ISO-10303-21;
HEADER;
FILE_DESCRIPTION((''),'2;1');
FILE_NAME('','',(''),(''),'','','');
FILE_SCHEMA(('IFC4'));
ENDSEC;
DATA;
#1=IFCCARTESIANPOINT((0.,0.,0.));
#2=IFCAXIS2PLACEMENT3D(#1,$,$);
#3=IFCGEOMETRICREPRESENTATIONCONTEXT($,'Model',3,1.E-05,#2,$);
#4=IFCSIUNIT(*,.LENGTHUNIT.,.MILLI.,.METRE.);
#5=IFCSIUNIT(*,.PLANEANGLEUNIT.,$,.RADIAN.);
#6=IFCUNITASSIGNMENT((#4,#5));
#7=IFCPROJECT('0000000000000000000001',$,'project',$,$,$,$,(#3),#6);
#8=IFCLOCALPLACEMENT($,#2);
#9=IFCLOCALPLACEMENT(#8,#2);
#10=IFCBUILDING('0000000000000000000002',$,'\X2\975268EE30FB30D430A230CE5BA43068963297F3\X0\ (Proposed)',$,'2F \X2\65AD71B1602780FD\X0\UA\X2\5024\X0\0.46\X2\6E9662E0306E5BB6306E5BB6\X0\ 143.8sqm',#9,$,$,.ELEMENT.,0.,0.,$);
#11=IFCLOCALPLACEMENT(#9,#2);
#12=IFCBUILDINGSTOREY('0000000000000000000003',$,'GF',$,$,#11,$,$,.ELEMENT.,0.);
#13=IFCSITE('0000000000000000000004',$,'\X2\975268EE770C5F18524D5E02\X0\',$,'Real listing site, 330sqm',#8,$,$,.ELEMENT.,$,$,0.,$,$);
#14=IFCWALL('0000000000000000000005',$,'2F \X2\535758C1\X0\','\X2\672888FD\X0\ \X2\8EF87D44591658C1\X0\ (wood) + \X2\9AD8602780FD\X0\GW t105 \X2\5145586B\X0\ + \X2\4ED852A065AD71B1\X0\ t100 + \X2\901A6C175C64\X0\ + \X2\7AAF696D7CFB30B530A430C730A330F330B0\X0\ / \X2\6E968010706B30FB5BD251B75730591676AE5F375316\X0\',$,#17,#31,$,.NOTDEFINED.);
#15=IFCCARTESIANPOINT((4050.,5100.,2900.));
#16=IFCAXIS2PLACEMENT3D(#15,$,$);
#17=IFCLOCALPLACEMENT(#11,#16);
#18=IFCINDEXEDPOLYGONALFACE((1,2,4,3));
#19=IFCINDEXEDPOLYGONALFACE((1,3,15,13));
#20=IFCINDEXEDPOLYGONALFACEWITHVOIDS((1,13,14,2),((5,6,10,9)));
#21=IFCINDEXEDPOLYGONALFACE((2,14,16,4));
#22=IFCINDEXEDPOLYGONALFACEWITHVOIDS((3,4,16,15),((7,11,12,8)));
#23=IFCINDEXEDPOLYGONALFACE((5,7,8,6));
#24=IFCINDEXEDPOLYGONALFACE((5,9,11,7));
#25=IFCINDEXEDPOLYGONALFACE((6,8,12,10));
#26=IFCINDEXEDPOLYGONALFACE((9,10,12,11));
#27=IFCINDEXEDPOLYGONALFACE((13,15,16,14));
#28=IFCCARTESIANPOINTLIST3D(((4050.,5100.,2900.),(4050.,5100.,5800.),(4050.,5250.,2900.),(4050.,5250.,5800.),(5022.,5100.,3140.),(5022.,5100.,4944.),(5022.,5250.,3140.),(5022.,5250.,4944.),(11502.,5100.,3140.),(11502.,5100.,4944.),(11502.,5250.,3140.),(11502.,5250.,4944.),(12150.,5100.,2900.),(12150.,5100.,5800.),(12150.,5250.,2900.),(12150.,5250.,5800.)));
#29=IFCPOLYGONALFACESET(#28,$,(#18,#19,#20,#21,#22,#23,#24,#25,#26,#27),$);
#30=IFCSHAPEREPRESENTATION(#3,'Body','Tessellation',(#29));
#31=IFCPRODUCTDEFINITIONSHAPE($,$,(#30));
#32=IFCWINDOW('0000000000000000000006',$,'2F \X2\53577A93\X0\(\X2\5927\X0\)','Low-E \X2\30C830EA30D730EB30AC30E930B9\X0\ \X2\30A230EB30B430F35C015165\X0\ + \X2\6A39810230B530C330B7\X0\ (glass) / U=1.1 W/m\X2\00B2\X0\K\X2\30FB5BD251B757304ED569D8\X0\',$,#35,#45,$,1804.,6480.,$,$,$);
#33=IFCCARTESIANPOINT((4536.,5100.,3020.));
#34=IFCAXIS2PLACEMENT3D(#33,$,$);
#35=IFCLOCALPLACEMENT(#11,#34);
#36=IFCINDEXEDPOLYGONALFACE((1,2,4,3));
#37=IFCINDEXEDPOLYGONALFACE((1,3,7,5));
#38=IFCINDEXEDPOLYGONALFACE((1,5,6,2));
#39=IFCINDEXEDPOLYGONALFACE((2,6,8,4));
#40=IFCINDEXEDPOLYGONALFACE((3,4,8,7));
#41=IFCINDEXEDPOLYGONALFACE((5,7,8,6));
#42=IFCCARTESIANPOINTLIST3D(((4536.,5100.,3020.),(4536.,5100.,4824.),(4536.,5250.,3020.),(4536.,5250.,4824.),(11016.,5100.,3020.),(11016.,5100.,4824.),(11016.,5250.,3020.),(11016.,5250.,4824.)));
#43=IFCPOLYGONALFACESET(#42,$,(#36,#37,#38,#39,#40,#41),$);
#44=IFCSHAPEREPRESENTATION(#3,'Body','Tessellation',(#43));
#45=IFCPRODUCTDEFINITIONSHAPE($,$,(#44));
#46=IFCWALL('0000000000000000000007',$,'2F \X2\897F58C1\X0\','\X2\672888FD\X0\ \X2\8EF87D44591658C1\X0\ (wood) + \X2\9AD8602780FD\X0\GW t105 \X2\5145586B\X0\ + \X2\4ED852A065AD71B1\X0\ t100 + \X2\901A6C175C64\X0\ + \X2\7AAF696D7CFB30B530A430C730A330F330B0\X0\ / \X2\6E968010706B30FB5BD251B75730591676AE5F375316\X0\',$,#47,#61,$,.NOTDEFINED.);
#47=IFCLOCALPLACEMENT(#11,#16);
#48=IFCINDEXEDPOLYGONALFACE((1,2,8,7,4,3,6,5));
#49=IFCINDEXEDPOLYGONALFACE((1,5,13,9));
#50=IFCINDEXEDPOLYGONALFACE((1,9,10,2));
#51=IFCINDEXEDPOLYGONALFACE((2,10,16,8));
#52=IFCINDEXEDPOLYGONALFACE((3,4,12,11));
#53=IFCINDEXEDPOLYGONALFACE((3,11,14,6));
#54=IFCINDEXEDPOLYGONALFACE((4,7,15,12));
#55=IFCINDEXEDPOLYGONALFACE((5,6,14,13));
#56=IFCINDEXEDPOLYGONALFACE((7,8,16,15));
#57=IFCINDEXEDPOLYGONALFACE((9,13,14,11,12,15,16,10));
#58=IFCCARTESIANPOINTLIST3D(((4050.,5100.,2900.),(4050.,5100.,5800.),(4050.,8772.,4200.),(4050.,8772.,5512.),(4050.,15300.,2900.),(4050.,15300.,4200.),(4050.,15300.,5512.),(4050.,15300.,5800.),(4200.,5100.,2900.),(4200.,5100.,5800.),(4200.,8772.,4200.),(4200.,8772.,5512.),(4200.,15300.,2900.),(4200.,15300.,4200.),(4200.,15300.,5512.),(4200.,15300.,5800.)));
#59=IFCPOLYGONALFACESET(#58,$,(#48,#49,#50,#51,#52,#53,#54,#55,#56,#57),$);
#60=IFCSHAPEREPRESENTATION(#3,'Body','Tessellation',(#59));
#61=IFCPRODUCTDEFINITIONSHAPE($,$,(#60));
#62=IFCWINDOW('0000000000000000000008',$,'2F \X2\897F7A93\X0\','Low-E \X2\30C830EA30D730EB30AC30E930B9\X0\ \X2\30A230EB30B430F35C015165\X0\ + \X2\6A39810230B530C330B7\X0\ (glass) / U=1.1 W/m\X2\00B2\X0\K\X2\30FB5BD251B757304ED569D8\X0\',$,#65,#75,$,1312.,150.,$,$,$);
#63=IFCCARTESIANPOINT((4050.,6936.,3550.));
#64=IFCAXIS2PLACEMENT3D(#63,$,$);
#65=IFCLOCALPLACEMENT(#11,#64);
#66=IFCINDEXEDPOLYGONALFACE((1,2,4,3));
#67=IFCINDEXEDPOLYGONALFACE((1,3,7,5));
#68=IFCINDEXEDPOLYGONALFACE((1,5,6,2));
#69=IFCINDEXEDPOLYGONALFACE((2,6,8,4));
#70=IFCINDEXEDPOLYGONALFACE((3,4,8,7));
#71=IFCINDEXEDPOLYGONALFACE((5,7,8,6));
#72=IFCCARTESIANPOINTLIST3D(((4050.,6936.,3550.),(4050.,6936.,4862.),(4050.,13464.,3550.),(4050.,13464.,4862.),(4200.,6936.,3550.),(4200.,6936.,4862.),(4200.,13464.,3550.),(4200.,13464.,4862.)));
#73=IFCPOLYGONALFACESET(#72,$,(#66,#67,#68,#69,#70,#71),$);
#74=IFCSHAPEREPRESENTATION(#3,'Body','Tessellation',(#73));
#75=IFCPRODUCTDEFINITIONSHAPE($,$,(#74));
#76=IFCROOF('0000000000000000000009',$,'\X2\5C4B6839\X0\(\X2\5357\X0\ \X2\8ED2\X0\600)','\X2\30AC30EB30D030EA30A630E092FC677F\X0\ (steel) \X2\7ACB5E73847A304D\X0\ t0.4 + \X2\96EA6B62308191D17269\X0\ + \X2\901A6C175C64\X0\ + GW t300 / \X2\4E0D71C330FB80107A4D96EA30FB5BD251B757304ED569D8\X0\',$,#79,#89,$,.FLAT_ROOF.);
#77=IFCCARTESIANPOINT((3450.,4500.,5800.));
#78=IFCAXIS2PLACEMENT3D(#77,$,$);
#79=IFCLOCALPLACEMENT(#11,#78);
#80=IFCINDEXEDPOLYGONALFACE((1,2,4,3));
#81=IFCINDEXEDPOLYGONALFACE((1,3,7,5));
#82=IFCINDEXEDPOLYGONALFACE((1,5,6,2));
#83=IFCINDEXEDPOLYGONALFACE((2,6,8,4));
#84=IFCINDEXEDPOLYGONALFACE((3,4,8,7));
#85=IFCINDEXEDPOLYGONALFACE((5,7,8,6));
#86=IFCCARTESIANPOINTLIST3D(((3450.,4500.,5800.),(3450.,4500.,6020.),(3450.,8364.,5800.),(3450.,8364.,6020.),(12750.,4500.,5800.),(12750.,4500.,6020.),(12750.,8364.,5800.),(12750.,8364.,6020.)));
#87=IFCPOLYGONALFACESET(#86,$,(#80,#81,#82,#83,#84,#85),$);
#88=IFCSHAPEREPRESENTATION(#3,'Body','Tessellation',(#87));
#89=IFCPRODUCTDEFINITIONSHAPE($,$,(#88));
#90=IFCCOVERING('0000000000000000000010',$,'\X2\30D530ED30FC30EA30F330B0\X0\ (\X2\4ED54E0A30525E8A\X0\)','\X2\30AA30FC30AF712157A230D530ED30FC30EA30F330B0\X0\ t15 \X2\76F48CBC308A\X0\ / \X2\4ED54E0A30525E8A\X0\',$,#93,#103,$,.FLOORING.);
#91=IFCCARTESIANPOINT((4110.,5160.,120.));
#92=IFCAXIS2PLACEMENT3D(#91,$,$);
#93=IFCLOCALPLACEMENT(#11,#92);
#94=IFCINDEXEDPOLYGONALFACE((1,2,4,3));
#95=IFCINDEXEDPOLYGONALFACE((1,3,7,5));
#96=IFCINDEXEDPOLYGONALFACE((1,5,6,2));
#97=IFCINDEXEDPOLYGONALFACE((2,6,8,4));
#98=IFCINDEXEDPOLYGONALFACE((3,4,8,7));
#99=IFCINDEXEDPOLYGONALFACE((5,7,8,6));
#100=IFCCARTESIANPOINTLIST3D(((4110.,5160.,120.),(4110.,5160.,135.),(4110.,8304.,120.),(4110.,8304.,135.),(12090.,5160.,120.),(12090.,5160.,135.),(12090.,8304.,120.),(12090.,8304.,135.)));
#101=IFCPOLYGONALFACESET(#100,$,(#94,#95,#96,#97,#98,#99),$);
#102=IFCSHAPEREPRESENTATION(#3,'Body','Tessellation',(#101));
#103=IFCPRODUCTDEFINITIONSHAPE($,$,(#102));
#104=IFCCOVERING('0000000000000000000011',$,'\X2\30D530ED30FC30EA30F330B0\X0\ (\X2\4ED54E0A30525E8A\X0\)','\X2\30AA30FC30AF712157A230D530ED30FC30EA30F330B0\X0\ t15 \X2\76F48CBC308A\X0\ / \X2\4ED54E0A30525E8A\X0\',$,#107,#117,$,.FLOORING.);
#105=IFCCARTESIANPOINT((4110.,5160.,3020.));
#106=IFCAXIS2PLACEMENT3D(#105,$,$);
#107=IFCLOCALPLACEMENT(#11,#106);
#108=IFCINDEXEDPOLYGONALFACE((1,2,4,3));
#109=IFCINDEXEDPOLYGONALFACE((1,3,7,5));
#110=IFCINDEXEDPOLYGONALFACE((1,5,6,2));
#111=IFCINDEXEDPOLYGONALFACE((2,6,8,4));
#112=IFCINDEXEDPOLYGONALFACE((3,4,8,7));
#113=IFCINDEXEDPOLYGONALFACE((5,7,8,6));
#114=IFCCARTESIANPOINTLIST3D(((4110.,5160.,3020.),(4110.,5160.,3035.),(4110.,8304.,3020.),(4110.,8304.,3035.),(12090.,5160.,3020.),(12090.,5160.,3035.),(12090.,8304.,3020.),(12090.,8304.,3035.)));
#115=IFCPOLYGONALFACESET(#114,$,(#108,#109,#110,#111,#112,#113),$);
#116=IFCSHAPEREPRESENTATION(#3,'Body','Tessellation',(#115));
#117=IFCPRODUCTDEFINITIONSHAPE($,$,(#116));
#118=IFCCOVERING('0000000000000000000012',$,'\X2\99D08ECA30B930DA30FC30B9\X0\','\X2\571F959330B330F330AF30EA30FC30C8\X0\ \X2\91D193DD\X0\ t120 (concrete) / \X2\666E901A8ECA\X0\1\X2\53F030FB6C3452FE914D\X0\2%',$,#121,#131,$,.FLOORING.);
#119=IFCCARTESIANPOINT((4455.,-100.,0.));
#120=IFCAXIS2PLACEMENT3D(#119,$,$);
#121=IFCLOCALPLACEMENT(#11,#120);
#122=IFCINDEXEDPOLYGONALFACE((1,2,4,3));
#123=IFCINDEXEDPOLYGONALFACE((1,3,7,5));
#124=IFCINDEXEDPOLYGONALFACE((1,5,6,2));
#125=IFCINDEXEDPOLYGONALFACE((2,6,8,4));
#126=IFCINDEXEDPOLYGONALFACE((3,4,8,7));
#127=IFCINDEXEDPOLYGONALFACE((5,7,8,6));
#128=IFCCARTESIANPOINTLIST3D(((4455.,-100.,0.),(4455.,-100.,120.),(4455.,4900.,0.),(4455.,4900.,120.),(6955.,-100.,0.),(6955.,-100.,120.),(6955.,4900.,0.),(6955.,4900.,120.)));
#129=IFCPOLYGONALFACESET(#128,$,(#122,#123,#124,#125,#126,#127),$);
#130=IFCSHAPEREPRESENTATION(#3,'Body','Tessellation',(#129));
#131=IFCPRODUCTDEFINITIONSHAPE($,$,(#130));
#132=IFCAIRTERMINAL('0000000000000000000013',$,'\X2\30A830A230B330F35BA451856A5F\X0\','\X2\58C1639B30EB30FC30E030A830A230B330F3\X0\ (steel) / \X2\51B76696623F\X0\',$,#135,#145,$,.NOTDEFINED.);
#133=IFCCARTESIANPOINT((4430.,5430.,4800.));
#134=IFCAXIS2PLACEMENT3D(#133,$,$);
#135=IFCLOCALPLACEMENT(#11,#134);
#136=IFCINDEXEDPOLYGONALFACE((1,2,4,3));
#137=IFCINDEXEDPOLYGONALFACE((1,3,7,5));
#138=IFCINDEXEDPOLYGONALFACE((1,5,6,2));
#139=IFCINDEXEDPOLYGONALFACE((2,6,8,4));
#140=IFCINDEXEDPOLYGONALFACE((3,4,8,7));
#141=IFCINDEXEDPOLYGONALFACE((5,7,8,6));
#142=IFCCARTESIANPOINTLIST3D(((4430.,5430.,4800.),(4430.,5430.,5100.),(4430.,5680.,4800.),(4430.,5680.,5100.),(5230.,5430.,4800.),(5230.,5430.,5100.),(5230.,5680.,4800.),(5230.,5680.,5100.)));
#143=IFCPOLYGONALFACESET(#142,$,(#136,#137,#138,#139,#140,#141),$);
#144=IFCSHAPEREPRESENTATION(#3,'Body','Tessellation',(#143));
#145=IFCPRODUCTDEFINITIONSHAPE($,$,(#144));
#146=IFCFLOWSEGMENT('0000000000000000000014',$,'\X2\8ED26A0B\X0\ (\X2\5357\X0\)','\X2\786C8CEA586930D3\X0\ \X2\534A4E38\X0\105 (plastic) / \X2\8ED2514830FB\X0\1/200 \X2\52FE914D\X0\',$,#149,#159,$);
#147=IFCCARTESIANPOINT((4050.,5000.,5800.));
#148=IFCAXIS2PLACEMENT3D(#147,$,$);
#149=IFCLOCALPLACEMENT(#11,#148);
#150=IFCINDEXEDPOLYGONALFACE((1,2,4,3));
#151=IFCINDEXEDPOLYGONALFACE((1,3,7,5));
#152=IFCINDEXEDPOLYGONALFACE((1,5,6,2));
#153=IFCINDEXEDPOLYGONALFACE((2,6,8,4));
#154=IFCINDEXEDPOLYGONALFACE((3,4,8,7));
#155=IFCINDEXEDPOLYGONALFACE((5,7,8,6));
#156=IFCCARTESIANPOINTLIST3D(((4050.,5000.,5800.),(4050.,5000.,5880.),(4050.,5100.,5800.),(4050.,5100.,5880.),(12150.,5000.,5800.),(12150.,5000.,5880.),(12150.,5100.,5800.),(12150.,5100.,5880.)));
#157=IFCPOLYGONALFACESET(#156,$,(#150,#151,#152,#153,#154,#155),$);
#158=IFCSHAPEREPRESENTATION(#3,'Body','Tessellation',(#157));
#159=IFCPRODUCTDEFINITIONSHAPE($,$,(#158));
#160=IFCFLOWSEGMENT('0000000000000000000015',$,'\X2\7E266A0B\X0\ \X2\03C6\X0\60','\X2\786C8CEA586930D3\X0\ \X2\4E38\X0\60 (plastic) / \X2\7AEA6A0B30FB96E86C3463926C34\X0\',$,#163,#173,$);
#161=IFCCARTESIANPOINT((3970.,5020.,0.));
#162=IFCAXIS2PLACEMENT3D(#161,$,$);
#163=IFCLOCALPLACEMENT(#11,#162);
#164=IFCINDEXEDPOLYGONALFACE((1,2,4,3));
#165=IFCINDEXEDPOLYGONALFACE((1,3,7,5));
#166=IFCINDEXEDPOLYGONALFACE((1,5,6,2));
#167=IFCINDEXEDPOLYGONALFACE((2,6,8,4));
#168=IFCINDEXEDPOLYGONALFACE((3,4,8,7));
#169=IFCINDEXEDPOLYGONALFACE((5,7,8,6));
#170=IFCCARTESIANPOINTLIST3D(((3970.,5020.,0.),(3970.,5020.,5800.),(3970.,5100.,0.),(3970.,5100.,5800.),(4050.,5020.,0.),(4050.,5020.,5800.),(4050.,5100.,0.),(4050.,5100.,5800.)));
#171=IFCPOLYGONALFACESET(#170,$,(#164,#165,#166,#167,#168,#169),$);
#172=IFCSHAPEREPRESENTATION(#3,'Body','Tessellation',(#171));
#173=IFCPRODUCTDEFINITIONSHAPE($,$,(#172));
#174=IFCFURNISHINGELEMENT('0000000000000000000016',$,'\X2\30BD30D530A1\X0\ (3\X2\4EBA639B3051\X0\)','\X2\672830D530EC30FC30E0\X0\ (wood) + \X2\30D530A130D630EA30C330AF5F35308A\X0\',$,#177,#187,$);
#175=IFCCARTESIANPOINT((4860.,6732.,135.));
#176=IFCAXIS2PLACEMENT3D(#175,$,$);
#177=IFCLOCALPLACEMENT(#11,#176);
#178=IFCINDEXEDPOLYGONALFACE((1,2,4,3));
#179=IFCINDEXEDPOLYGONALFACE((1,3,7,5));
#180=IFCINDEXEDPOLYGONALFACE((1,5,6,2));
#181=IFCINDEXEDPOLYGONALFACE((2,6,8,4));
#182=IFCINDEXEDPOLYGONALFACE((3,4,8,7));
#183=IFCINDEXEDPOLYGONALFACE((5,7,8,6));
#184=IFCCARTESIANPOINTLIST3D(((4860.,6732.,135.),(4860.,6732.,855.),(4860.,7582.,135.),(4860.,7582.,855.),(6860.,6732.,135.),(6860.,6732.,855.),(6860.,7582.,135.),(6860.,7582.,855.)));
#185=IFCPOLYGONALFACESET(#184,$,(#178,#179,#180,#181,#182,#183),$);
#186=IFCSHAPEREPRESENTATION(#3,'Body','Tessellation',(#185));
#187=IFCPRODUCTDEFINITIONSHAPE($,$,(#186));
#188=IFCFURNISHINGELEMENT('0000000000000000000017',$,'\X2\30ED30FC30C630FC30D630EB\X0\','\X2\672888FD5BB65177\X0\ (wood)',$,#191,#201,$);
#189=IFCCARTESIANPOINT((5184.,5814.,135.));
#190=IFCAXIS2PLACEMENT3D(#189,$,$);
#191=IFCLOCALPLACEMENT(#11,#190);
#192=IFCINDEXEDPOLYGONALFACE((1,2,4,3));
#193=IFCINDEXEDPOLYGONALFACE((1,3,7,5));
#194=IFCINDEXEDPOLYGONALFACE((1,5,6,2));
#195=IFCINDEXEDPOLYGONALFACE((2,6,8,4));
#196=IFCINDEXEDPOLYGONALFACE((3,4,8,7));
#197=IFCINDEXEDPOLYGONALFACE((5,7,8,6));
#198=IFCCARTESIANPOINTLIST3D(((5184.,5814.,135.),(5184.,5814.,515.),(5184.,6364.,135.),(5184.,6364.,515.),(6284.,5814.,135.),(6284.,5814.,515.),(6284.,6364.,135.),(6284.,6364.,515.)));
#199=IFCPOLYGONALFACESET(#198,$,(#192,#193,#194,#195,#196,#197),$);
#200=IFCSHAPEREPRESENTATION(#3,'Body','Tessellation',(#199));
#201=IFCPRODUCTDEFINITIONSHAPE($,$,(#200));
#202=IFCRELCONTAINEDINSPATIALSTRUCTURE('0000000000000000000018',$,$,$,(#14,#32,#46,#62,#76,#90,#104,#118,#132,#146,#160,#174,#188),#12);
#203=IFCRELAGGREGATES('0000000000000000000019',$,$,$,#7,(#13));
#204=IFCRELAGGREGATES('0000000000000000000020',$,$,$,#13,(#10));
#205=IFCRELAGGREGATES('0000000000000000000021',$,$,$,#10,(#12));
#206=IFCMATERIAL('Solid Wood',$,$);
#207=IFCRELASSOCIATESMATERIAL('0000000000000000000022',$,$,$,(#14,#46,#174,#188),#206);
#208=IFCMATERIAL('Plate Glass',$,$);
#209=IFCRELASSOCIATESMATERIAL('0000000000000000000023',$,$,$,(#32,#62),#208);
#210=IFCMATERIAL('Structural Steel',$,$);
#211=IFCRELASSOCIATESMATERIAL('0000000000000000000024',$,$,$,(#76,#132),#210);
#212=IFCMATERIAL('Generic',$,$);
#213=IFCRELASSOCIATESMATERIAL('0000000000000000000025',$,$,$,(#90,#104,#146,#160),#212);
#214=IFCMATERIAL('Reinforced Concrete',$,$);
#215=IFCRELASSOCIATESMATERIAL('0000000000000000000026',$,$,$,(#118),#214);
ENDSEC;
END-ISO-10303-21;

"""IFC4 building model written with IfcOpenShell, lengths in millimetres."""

from ifc_helpers import new_model, si_unit, frame, frame_2d, origin, place, context, project, spatial, rectangle, extrude, material, element, fill, save


model = new_model("IFC4")

# Units and contexts
model_context = context("Model", 3, precision=1e-05, world=origin())
ifc_project = project(units=[si_unit("LENGTHUNIT", "METRE", prefix="MILLI"), si_unit("PLANEANGLEUNIT", "RADIAN")], contexts=[model_context])

# Site, building, storey
site_placement = place(None, origin())
site = spatial("IfcSite", under=ifc_project, at=site_placement, Name="青森県弘前市", ObjectType="Real listing site, 330sqm", CompositionType="ELEMENT", RefElevation=0.0)
building_placement = place(site_placement, origin())
building = spatial("IfcBuilding", under=site, at=building_placement, Name="青森・ピアノ室と防音 (Proposed)", ObjectType="2F 断熱性能UA値0.46準拠の家の家 143.8sqm", CompositionType="ELEMENT", ElevationOfRefHeight=0.0, ElevationOfTerrain=0.0)
storey_placement = place(building_placement, origin())
storey = spatial("IfcBuildingStorey", under=building, at=storey_placement, Name="GF", CompositionType="ELEMENT", Elevation=0.0)

# Shared definitions
ifc_material_1 = material(Name="Solid Wood")

# Shared definitions
ifc_material_2 = material(Name="Reinforced Concrete")

# Shared definitions
ifc_material_3 = material(Name="Plate Glass")

# Walls, openings, windows
wall_1_placement = place(storey_placement, frame((4050.0, 5100.0, 2900.0)))
wall_1 = element("IfcWall", 1, at=wall_1_placement, inside=storey, material=ifc_material_1, Name="2F 南壁", Description="木製 軸組外壁 (wood) + 高性能GW t105 充填 + 付加断熱 t100 + 通気層 + 窯業系サイディング / 準耐火・寒冷地外皮強化", PredefinedType="NOTDEFINED", context=model_context, shape_type="SweptSolid", body=[
    extrude(rectangle(XDim=8100.0, YDim=150.0, at=frame_2d((4050.0, 75.0))), frame((4050.0, 5100.0, 2900.0)), (0.0, 0.0, 1.0), 2900.0),
])
opening_1_placement = place(storey_placement, frame((4536.0, 5100.0, 3020.0)))
opening_1 = element("IfcOpeningElement", 2, at=opening_1_placement, cuts=wall_1, PredefinedType="NOTDEFINED", context=model_context, shape_type="SweptSolid", body=[
    extrude(rectangle(XDim=6480.0, YDim=150.0, at=frame_2d((3240.0, 75.0))), frame((4536.0, 5100.0, 3020.0)), (0.0, 0.0, 1.0), 1804.0),
])
window_1_placement = place(storey_placement, frame((4536.0, 5100.0, 3020.0)))
window_1 = element("IfcWindow", 3, at=window_1_placement, inside=storey, material=ifc_material_3, Name="2F 南窓(大)", Description="Low-E トリプルガラス アルゴン封入 + 樹脂サッシ (glass) / U=1.1 W/m²K・寒冷地仕様", OverallHeight=1804.0, OverallWidth=6480.0, context=model_context, shape_type="SweptSolid", body=[
    extrude(rectangle(XDim=6480.0, YDim=150.0, at=frame_2d((3240.0, 75.0))), frame((4536.0, 5100.0, 3020.0)), (0.0, 0.0, 1.0), 1804.0),
])
fill(opening_1, window_1)
wall_2_placement = place(storey_placement, frame((4050.0, 5100.0, 2900.0)))
wall_2 = element("IfcWall", 4, at=wall_2_placement, inside=storey, material=ifc_material_1, Name="2F 西壁", Description="木製 軸組外壁 (wood) + 高性能GW t105 充填 + 付加断熱 t100 + 通気層 + 窯業系サイディング / 準耐火・寒冷地外皮強化", PredefinedType="NOTDEFINED", context=model_context, shape_type="SweptSolid", body=[
    extrude(rectangle(XDim=150.0, YDim=10200.0, at=frame_2d((75.0, 5100.0))), frame((4050.0, 5100.0, 2900.0)), (0.0, 0.0, 1.0), 2900.0),
])
opening_2_placement = place(storey_placement, frame((4050.0, 6936.0, 3550.0)))
opening_2 = element("IfcOpeningElement", 5, at=opening_2_placement, cuts=wall_2, PredefinedType="NOTDEFINED", context=model_context, shape_type="SweptSolid", body=[
    extrude(rectangle(XDim=150.0, YDim=6528.0, at=frame_2d((75.0, 3264.0))), frame((4050.0, 6936.0, 3550.0)), (0.0, 0.0, 1.0), 1312.0),
])
window_2_placement = place(storey_placement, frame((4050.0, 6936.0, 3550.0)))
window_2 = element("IfcWindow", 6, at=window_2_placement, inside=storey, material=ifc_material_3, Name="2F 西窓", Description="Low-E トリプルガラス アルゴン封入 + 樹脂サッシ (glass) / U=1.1 W/m²K・寒冷地仕様", OverallHeight=1312.0, OverallWidth=150.0, context=model_context, shape_type="SweptSolid", body=[
    extrude(rectangle(XDim=150.0, YDim=6528.0, at=frame_2d((75.0, 3264.0))), frame((4050.0, 6936.0, 3550.0)), (0.0, 0.0, 1.0), 1312.0),
])
fill(opening_2, window_2)

# Roof
ifc_material_4 = material(Name="Structural Steel")
for number, where, name in (
    (7, (3450.0, 4500.0, 5800.0), "屋根(南 軒600)"),
):
    element("IfcRoof", number, at=place(storey_placement, frame(where)), inside=storey, material=ifc_material_4, Name=name, Description="ガルバリウム鋼板 (steel) 立平葺き t0.4 + 雪止め金物 + 通気層 + GW t300 / 不燃・耐積雪・寒冷地仕様", PredefinedType="FLAT_ROOF", context=model_context, shape_type="SweptSolid", body=[
        extrude(rectangle(XDim=9300.0, YDim=3864.0, at=frame_2d((4650.0, 1932.0))), frame((3450.0, 4500.0, 5800.0)), (0.0, 0.0, 1.0), 220.0),
    ])

# Coverings
ifc_material_5 = material(Name="Generic")
covering_1_placement = place(storey_placement, frame((4110.0, 5160.0, 120.0)))
element("IfcCovering", 8, at=covering_1_placement, inside=storey, material=ifc_material_5, Name="フローリング (仕上げ床)", Description="オーク無垢フローリング t15 直貼り / 仕上げ床", PredefinedType="FLOORING", context=model_context, shape_type="SweptSolid", body=[
    extrude(rectangle(XDim=7980.0, YDim=3144.0, at=frame_2d((3990.0, 1572.0))), frame((4110.0, 5160.0, 120.0)), (0.0, 0.0, 1.0), 15.0),
])
covering_2_placement = place(storey_placement, frame((4110.0, 5160.0, 3020.0)))
element("IfcCovering", 9, at=covering_2_placement, inside=storey, material=ifc_material_5, Name="フローリング (仕上げ床)", Description="オーク無垢フローリング t15 直貼り / 仕上げ床", PredefinedType="FLOORING", context=model_context, shape_type="SweptSolid", body=[
    extrude(rectangle(XDim=7980.0, YDim=3144.0, at=frame_2d((3990.0, 1572.0))), frame((4110.0, 5160.0, 3020.0)), (0.0, 0.0, 1.0), 15.0),
])
covering_3_placement = place(storey_placement, frame((4455.0, -100.0, 0.0)))
element("IfcCovering", 10, at=covering_3_placement, inside=storey, material=ifc_material_2, Name="駐車スペース", Description="土間コンクリート 金鏝 t120 (concrete) / 普通車1台・水勾配2%", PredefinedType="FLOORING", context=model_context, shape_type="SweptSolid", body=[
    extrude(rectangle(XDim=2500.0, YDim=5000.0, at=frame_2d((1250.0, 2500.0))), frame((4455.0, -100.0, 0.0)), (0.0, 0.0, 1.0), 120.0),
])

# Air terminal
air_terminal_placement = place(storey_placement, frame((4430.0, 5430.0, 4800.0)))
element("IfcAirTerminal", 11, at=air_terminal_placement, inside=storey, material=ifc_material_4, Name="エアコン室内機", Description="壁掛ルームエアコン (steel) / 冷暖房", PredefinedType="NOTDEFINED", context=model_context, shape_type="SweptSolid", body=[
    extrude(rectangle(XDim=800.0, YDim=250.0, at=frame_2d((400.0, 125.0))), frame((4430.0, 5430.0, 4800.0)), (0.0, 0.0, 1.0), 300.0),
])

# Flow segments
flow_segment_1_placement = place(storey_placement, frame((4050.0, 5000.0, 5800.0)))
element("IfcFlowSegment", 12, at=flow_segment_1_placement, inside=storey, material=ifc_material_5, Name="軒樋 (南)", Description="硬質塩ビ 半丸105 (plastic) / 軒先・1/200 勾配", context=model_context, shape_type="SweptSolid", body=[
    extrude(rectangle(XDim=8100.0, YDim=100.0, at=frame_2d((4050.0, 50.0))), frame((4050.0, 5000.0, 5800.0)), (0.0, 0.0, 1.0), 80.0),
])
flow_segment_2_placement = place(storey_placement, frame((3970.0, 5020.0, 0.0)))
element("IfcFlowSegment", 13, at=flow_segment_2_placement, inside=storey, material=ifc_material_5, Name="縦樋 φ60", Description="硬質塩ビ 丸60 (plastic) / 竪樋・雨水排水", context=model_context, shape_type="SweptSolid", body=[
    extrude(rectangle(XDim=80.0, YDim=80.0, at=frame_2d((40.0, 40.0))), frame((3970.0, 5020.0, 0.0)), (0.0, 0.0, 1.0), 5800.0),
])

# Furnishing elements
furnishing_1_placement = place(storey_placement, frame((4860.0, 6732.0, 135.0)))
element("IfcFurnishingElement", 14, at=furnishing_1_placement, inside=storey, material=ifc_material_1, Name="ソファ (3人掛け)", Description="木フレーム (wood) + ファブリック張り", context=model_context, shape_type="SweptSolid", body=[
    extrude(rectangle(XDim=2000.0, YDim=850.0, at=frame_2d((1000.0, 425.0))), frame((4860.0, 6732.0, 135.0)), (0.0, 0.0, 1.0), 720.0),
])
furnishing_2_placement = place(storey_placement, frame((5184.0, 5814.0, 135.0)))
element("IfcFurnishingElement", 15, at=furnishing_2_placement, inside=storey, material=ifc_material_1, Name="ローテーブル", Description="木製家具 (wood)", context=model_context, shape_type="SweptSolid", body=[
    extrude(rectangle(XDim=1100.0, YDim=550.0, at=frame_2d((550.0, 275.0))), frame((5184.0, 5814.0, 135.0)), (0.0, 0.0, 1.0), 380.0),
])

save(model, "model.ifc")
